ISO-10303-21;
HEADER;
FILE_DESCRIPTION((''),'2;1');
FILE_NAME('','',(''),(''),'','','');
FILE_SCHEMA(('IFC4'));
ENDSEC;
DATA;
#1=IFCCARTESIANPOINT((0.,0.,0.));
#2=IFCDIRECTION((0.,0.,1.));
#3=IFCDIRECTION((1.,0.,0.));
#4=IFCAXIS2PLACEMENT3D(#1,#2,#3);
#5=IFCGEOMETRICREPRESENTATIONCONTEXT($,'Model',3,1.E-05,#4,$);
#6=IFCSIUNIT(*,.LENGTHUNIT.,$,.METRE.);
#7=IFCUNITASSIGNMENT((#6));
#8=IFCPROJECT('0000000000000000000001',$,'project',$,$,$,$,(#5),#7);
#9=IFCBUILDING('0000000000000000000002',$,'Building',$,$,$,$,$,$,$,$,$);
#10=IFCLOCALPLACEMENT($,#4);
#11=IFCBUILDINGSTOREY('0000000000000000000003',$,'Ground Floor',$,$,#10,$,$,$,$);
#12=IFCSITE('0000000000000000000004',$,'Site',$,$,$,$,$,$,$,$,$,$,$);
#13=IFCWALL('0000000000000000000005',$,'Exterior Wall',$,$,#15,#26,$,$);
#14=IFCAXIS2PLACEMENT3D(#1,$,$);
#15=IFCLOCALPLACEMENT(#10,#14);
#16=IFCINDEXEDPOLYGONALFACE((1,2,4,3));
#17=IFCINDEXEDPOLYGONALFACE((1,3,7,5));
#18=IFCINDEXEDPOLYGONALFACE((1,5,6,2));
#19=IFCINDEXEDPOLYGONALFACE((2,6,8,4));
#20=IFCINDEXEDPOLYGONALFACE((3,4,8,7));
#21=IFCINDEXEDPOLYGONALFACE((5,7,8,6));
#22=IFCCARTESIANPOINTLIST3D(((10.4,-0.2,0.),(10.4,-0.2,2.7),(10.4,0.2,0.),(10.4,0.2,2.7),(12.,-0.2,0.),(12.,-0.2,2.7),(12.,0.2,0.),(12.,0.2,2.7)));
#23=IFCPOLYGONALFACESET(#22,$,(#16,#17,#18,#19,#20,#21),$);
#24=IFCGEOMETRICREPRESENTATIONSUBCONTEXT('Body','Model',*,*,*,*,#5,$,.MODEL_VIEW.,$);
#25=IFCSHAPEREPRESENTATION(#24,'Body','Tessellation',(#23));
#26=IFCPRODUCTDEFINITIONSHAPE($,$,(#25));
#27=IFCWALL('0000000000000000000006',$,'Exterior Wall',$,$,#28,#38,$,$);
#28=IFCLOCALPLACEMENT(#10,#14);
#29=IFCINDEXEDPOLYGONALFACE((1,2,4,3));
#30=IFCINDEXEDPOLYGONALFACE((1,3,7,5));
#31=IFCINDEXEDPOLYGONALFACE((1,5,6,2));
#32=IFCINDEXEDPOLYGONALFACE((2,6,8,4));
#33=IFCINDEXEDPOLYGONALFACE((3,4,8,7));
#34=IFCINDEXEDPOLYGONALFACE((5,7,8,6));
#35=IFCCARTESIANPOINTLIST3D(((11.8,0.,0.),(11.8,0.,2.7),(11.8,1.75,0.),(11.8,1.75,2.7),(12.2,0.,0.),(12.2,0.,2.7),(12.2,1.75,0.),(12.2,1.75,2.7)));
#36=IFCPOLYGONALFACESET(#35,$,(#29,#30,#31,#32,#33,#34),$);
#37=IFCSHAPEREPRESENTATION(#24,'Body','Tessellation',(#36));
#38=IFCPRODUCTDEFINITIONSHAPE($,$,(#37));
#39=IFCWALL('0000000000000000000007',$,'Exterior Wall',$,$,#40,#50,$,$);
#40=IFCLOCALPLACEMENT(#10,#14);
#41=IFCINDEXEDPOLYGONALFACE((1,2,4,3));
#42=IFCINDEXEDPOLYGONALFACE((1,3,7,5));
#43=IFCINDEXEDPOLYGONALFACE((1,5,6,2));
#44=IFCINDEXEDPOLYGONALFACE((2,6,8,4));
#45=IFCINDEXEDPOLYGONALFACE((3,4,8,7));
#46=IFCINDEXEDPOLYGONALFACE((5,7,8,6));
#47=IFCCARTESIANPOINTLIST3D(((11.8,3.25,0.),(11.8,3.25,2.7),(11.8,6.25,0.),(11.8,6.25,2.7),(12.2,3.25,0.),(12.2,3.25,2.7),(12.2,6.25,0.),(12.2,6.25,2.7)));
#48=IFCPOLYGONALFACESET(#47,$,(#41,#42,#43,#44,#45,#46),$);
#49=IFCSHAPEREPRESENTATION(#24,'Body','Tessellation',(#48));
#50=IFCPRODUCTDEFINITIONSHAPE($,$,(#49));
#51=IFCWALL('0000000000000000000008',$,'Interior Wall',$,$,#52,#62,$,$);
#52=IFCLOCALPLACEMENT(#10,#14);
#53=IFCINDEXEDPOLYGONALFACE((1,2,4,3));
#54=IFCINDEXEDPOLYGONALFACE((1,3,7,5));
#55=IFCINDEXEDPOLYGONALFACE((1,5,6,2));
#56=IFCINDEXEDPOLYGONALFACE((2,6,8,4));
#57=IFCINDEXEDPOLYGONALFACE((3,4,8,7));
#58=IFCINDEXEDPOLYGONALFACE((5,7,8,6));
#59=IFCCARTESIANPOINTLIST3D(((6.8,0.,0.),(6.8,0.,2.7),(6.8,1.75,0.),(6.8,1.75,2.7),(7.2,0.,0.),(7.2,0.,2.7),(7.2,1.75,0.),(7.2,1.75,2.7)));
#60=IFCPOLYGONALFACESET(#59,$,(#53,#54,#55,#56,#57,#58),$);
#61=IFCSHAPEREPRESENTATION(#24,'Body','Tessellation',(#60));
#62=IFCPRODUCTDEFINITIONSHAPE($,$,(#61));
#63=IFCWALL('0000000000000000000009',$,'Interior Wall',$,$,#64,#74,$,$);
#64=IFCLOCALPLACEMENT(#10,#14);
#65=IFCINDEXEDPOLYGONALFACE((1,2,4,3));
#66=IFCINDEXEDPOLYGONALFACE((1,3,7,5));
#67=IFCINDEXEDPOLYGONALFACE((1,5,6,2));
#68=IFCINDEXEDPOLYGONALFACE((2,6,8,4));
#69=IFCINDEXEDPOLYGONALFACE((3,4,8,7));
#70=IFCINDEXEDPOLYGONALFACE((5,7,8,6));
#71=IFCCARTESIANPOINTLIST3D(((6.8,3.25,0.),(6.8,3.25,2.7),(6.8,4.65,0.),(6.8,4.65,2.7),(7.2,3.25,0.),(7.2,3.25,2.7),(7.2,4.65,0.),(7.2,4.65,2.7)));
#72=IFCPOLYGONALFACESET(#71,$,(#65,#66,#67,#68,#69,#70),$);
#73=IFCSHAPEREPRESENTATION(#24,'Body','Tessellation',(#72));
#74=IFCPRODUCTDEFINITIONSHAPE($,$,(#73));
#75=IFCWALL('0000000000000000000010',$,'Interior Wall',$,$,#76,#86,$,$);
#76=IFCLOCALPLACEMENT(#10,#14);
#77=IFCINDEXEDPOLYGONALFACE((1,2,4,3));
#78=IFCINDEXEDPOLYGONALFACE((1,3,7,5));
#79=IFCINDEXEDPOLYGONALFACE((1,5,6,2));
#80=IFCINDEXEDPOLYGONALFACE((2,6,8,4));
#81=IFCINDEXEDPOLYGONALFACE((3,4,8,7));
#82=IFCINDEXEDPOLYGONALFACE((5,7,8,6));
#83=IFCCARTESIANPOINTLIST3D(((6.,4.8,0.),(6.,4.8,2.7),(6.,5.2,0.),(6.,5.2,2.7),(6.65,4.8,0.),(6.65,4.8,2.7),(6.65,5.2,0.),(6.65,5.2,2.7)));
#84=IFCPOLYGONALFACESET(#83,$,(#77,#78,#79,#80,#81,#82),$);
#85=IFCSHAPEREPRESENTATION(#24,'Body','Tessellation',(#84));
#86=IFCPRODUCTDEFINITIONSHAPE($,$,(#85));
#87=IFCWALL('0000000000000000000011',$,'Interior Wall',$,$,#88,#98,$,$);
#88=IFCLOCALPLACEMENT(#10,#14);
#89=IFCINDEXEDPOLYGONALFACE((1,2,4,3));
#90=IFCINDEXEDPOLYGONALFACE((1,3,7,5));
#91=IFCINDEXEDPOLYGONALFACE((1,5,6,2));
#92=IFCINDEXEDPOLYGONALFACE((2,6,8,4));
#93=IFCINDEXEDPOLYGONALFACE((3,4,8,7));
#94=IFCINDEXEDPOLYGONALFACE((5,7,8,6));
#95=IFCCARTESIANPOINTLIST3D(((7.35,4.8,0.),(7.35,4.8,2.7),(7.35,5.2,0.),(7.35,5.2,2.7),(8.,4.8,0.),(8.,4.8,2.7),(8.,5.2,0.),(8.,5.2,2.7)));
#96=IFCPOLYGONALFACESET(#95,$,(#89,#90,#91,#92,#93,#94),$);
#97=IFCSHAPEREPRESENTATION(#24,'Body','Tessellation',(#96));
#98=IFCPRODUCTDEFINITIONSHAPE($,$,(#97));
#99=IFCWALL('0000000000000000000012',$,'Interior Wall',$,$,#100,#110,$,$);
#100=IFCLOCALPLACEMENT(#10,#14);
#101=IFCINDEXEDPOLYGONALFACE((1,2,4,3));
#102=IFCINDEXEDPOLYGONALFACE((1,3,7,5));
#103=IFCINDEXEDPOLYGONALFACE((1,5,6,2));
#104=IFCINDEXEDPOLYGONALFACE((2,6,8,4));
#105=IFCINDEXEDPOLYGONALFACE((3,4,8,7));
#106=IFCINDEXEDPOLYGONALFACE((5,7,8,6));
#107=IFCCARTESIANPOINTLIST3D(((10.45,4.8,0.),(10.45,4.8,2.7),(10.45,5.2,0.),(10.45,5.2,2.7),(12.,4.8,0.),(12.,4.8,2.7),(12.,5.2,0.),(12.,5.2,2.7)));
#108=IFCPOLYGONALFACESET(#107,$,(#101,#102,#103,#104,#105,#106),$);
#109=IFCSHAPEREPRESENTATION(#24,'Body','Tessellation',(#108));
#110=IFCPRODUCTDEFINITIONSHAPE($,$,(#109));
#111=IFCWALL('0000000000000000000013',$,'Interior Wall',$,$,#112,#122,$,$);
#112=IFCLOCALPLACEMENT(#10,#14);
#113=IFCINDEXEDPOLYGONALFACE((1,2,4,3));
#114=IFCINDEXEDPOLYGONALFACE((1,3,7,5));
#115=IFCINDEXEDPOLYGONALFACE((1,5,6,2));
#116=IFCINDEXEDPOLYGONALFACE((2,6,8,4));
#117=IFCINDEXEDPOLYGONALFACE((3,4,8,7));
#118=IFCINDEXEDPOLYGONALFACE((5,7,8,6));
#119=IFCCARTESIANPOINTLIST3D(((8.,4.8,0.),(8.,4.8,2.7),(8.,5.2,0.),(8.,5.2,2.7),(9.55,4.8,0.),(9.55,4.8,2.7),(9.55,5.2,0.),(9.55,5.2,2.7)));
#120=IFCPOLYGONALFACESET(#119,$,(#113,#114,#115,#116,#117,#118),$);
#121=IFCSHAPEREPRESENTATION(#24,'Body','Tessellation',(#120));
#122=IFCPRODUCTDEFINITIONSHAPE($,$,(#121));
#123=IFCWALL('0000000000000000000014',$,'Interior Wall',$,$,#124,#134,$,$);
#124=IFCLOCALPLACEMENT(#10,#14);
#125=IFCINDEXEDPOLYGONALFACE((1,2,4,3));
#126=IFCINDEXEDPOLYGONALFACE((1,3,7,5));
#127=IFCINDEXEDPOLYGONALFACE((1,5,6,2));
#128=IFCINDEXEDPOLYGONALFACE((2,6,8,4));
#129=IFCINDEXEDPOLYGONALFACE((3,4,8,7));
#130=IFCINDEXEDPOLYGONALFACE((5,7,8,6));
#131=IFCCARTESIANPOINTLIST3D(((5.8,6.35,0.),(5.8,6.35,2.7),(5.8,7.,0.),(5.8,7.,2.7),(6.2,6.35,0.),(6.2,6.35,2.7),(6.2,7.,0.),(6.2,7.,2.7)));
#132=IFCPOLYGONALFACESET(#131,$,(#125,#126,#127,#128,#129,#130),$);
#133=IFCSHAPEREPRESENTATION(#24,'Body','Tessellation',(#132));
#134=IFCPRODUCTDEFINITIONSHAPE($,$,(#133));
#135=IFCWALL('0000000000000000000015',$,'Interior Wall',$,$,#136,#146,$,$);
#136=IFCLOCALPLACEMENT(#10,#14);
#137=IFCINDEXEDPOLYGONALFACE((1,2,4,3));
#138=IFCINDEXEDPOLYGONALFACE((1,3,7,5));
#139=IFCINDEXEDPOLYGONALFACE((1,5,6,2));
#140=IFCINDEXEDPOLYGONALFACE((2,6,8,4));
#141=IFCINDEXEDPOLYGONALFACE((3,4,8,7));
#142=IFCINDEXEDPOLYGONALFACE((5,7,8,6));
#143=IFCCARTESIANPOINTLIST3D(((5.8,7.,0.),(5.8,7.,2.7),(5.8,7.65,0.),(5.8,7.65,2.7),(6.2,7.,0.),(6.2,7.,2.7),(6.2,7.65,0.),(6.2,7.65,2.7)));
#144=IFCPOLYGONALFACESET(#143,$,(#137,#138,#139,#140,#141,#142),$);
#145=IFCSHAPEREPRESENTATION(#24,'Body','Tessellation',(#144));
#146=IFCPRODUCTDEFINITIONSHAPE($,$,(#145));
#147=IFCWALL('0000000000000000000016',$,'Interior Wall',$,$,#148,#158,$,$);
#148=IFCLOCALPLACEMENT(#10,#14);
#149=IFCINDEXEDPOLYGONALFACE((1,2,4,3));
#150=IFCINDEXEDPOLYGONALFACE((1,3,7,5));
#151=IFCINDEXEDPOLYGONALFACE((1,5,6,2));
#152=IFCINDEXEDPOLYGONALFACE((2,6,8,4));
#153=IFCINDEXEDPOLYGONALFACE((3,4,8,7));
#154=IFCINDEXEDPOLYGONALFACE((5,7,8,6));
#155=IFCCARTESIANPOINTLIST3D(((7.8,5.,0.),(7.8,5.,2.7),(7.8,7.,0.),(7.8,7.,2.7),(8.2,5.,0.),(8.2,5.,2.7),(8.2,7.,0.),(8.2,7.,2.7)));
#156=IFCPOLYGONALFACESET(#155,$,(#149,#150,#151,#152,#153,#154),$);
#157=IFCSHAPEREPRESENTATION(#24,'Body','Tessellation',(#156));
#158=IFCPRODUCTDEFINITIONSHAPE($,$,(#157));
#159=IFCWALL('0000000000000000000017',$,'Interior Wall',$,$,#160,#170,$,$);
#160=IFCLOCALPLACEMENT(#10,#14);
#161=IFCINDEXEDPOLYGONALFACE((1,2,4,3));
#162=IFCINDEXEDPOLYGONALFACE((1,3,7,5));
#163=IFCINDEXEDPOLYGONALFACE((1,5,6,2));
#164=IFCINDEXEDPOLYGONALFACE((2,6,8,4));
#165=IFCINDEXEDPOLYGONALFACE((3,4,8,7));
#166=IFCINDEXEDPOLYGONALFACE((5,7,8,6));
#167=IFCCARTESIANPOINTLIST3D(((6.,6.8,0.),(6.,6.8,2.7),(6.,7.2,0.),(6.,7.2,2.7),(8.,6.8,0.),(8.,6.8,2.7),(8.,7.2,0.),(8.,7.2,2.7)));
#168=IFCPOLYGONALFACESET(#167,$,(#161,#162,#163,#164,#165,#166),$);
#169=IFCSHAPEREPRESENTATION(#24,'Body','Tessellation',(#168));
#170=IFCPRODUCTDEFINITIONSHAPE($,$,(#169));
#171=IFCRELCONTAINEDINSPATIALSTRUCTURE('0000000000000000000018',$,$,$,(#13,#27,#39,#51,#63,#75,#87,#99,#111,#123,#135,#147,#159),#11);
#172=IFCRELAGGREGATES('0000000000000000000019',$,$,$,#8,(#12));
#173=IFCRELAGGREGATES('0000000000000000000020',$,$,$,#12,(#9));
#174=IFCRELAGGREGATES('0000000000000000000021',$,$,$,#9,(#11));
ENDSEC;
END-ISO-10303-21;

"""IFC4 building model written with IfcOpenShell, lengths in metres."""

from ifc_helpers import new_model, si_unit, frame, origin_with_axes, place, context, subcontext, project, spatial, indexed_curve, outline, extrude, element, save


model = new_model("IFC4")

# Units and contexts
model_context = context("Model", 3, precision=1e-05, world=origin_with_axes())
body_context = subcontext(model_context, "Body", "Model", "MODEL_VIEW")
ifc_project = project(units=[si_unit("LENGTHUNIT", "METRE")], contexts=[model_context])

# Site, building, storey
site = spatial("IfcSite", under=ifc_project, Name="Site")
building = spatial("IfcBuilding", under=site, Name="Building")
storey_placement = place(None, origin_with_axes())
storey = spatial("IfcBuildingStorey", under=building, at=storey_placement, Name="Ground Floor")

# Walls
wall_1_placement = place(storey_placement, frame((10.4, 0.0, 0.0), z_axis=(0.0, 0.0, 1.0), x_axis=(1.0, 0.0, 0.0)))
element("IfcWall", 1, at=wall_1_placement, inside=storey, Name="Exterior Wall", context=body_context, shape_type="SweptSolid", body=[
    extrude(outline(indexed_curve([(0.0, 0.0), (0.0, 0.4), (1.6, 0.4), (1.6, 0.0), (0.0, 0.0)], self_intersect=False)), frame((0.0, -0.2, 0.0), z_axis=(0.0, 0.0, 1.0), x_axis=(1.0, 0.0, 0.0)), (0.0, 0.0, 1.0), 2.7),
])
wall_2_placement = place(storey_placement, frame((12.0, 0.0, 0.0), z_axis=(0.0, 0.0, 1.0), x_axis=(0.0, 1.0, 0.0)))
element("IfcWall", 2, at=wall_2_placement, inside=storey, Name="Exterior Wall", context=body_context, shape_type="SweptSolid", body=[
    extrude(outline(indexed_curve([(0.0, 0.0), (0.0, 0.4), (1.75, 0.4), (1.75, 0.0), (0.0, 0.0)], self_intersect=False)), frame((0.0, -0.2, 0.0), z_axis=(0.0, 0.0, 1.0), x_axis=(1.0, 0.0, 0.0)), (0.0, 0.0, 1.0), 2.7),
])
wall_3_placement = place(storey_placement, frame((12.0, 3.25, 0.0), z_axis=(0.0, 0.0, 1.0), x_axis=(0.0, 1.0, 0.0)))
element("IfcWall", 3, at=wall_3_placement, inside=storey, Name="Exterior Wall", context=body_context, shape_type="SweptSolid", body=[
    extrude(outline(indexed_curve([(0.0, 0.0), (0.0, 0.4), (3.0, 0.4), (3.0, 0.0), (0.0, 0.0)], self_intersect=False)), frame((0.0, -0.2, 0.0), z_axis=(0.0, 0.0, 1.0), x_axis=(1.0, 0.0, 0.0)), (0.0, 0.0, 1.0), 2.7),
])
wall_4_placement = place(storey_placement, frame((7.0, 0.0, 0.0), z_axis=(0.0, 0.0, 1.0), x_axis=(0.0, 1.0, 0.0)))
element("IfcWall", 4, at=wall_4_placement, inside=storey, Name="Interior Wall", context=body_context, shape_type="SweptSolid", body=[
    extrude(outline(indexed_curve([(0.0, 0.0), (0.0, 0.4), (1.75, 0.4), (1.75, 0.0), (0.0, 0.0)], self_intersect=False)), frame((0.0, -0.2, 0.0), z_axis=(0.0, 0.0, 1.0), x_axis=(1.0, 0.0, 0.0)), (0.0, 0.0, 1.0), 2.7),
])
wall_5_placement = place(storey_placement, frame((7.0, 3.25, 0.0), z_axis=(0.0, 0.0, 1.0), x_axis=(0.0, 1.0, 0.0)))
element("IfcWall", 5, at=wall_5_placement, inside=storey, Name="Interior Wall", context=body_context, shape_type="SweptSolid", body=[
    extrude(outline(indexed_curve([(0.0, 0.0), (0.0, 0.4), (1.4, 0.4), (1.4, 0.0), (0.0, 0.0)], self_intersect=False)), frame((0.0, -0.2, 0.0), z_axis=(0.0, 0.0, 1.0), x_axis=(1.0, 0.0, 0.0)), (0.0, 0.0, 1.0), 2.7),
])
for number, where, z_axis, x_axis, name in (
    (6, (6.65, 5.0, 0.0), (0.0, 0.0, 1.0), (-1.0, 0.0, 0.0), "Interior Wall"),
    (7, (8.0, 5.0, 0.0), (0.0, 0.0, 1.0), (-1.0, 0.0, 0.0), "Interior Wall"),
):
    element("IfcWall", number, at=place(storey_placement, frame(where, z_axis=z_axis, x_axis=x_axis)), inside=storey, Name=name, context=body_context, shape_type="SweptSolid", body=[
        extrude(outline(indexed_curve([(0.0, 0.0), (0.0, 0.4), (0.65, 0.4), (0.65, 0.0), (0.0, 0.0)], self_intersect=False)), frame((0.0, -0.2, 0.0), z_axis=(0.0, 0.0, 1.0), x_axis=(1.0, 0.0, 0.0)), (0.0, 0.0, 1.0), 2.7),
    ])
for number, where, z_axis, x_axis, name in (
    (8, (12.0, 5.0, 0.0), (0.0, 0.0, 1.0), (-1.0, 0.0, 0.0), "Interior Wall"),
    (9, (9.55, 5.0, 0.0), (0.0, 0.0, 1.0), (-1.0, 0.0, 0.0), "Interior Wall"),
):
    element("IfcWall", number, at=place(storey_placement, frame(where, z_axis=z_axis, x_axis=x_axis)), inside=storey, Name=name, context=body_context, shape_type="SweptSolid", body=[
        extrude(outline(indexed_curve([(0.0, 0.0), (0.0, 0.4), (1.55, 0.4), (1.55, 0.0), (0.0, 0.0)], self_intersect=False)), frame((0.0, -0.2, 0.0), z_axis=(0.0, 0.0, 1.0), x_axis=(1.0, 0.0, 0.0)), (0.0, 0.0, 1.0), 2.7),
    ])
for number, where, z_axis, x_axis, name in (
    (10, (6.0, 6.35, 0.0), (0.0, 0.0, 1.0), (0.0, 1.0, 0.0), "Interior Wall"),
    (11, (6.0, 7.0, 0.0), (0.0, 0.0, 1.0), (0.0, 1.0, 0.0), "Interior Wall"),
):
    element("IfcWall", number, at=place(storey_placement, frame(where, z_axis=z_axis, x_axis=x_axis)), inside=storey, Name=name, context=body_context, shape_type="SweptSolid", body=[
        extrude(outline(indexed_curve([(0.0, 0.0), (0.0, 0.4), (0.65, 0.4), (0.65, 0.0), (0.0, 0.0)], self_intersect=False)), frame((0.0, -0.2, 0.0), z_axis=(0.0, 0.0, 1.0), x_axis=(1.0, 0.0, 0.0)), (0.0, 0.0, 1.0), 2.7),
    ])
for number, where, z_axis, x_axis, name in (
    (12, (8.0, 5.0, 0.0), (0.0, 0.0, 1.0), (0.0, 1.0, 0.0), "Interior Wall"),
    (13, (8.0, 7.0, 0.0), (0.0, 0.0, 1.0), (-1.0, 0.0, 0.0), "Interior Wall"),
):
    element("IfcWall", number, at=place(storey_placement, frame(where, z_axis=z_axis, x_axis=x_axis)), inside=storey, Name=name, context=body_context, shape_type="SweptSolid", body=[
        extrude(outline(indexed_curve([(0.0, 0.0), (0.0, 0.4), (2.0, 0.4), (2.0, 0.0), (0.0, 0.0)], self_intersect=False)), frame((0.0, -0.2, 0.0), z_axis=(0.0, 0.0, 1.0), x_axis=(1.0, 0.0, 0.0)), (0.0, 0.0, 1.0), 2.7),
    ])

save(model, "model.ifc")
